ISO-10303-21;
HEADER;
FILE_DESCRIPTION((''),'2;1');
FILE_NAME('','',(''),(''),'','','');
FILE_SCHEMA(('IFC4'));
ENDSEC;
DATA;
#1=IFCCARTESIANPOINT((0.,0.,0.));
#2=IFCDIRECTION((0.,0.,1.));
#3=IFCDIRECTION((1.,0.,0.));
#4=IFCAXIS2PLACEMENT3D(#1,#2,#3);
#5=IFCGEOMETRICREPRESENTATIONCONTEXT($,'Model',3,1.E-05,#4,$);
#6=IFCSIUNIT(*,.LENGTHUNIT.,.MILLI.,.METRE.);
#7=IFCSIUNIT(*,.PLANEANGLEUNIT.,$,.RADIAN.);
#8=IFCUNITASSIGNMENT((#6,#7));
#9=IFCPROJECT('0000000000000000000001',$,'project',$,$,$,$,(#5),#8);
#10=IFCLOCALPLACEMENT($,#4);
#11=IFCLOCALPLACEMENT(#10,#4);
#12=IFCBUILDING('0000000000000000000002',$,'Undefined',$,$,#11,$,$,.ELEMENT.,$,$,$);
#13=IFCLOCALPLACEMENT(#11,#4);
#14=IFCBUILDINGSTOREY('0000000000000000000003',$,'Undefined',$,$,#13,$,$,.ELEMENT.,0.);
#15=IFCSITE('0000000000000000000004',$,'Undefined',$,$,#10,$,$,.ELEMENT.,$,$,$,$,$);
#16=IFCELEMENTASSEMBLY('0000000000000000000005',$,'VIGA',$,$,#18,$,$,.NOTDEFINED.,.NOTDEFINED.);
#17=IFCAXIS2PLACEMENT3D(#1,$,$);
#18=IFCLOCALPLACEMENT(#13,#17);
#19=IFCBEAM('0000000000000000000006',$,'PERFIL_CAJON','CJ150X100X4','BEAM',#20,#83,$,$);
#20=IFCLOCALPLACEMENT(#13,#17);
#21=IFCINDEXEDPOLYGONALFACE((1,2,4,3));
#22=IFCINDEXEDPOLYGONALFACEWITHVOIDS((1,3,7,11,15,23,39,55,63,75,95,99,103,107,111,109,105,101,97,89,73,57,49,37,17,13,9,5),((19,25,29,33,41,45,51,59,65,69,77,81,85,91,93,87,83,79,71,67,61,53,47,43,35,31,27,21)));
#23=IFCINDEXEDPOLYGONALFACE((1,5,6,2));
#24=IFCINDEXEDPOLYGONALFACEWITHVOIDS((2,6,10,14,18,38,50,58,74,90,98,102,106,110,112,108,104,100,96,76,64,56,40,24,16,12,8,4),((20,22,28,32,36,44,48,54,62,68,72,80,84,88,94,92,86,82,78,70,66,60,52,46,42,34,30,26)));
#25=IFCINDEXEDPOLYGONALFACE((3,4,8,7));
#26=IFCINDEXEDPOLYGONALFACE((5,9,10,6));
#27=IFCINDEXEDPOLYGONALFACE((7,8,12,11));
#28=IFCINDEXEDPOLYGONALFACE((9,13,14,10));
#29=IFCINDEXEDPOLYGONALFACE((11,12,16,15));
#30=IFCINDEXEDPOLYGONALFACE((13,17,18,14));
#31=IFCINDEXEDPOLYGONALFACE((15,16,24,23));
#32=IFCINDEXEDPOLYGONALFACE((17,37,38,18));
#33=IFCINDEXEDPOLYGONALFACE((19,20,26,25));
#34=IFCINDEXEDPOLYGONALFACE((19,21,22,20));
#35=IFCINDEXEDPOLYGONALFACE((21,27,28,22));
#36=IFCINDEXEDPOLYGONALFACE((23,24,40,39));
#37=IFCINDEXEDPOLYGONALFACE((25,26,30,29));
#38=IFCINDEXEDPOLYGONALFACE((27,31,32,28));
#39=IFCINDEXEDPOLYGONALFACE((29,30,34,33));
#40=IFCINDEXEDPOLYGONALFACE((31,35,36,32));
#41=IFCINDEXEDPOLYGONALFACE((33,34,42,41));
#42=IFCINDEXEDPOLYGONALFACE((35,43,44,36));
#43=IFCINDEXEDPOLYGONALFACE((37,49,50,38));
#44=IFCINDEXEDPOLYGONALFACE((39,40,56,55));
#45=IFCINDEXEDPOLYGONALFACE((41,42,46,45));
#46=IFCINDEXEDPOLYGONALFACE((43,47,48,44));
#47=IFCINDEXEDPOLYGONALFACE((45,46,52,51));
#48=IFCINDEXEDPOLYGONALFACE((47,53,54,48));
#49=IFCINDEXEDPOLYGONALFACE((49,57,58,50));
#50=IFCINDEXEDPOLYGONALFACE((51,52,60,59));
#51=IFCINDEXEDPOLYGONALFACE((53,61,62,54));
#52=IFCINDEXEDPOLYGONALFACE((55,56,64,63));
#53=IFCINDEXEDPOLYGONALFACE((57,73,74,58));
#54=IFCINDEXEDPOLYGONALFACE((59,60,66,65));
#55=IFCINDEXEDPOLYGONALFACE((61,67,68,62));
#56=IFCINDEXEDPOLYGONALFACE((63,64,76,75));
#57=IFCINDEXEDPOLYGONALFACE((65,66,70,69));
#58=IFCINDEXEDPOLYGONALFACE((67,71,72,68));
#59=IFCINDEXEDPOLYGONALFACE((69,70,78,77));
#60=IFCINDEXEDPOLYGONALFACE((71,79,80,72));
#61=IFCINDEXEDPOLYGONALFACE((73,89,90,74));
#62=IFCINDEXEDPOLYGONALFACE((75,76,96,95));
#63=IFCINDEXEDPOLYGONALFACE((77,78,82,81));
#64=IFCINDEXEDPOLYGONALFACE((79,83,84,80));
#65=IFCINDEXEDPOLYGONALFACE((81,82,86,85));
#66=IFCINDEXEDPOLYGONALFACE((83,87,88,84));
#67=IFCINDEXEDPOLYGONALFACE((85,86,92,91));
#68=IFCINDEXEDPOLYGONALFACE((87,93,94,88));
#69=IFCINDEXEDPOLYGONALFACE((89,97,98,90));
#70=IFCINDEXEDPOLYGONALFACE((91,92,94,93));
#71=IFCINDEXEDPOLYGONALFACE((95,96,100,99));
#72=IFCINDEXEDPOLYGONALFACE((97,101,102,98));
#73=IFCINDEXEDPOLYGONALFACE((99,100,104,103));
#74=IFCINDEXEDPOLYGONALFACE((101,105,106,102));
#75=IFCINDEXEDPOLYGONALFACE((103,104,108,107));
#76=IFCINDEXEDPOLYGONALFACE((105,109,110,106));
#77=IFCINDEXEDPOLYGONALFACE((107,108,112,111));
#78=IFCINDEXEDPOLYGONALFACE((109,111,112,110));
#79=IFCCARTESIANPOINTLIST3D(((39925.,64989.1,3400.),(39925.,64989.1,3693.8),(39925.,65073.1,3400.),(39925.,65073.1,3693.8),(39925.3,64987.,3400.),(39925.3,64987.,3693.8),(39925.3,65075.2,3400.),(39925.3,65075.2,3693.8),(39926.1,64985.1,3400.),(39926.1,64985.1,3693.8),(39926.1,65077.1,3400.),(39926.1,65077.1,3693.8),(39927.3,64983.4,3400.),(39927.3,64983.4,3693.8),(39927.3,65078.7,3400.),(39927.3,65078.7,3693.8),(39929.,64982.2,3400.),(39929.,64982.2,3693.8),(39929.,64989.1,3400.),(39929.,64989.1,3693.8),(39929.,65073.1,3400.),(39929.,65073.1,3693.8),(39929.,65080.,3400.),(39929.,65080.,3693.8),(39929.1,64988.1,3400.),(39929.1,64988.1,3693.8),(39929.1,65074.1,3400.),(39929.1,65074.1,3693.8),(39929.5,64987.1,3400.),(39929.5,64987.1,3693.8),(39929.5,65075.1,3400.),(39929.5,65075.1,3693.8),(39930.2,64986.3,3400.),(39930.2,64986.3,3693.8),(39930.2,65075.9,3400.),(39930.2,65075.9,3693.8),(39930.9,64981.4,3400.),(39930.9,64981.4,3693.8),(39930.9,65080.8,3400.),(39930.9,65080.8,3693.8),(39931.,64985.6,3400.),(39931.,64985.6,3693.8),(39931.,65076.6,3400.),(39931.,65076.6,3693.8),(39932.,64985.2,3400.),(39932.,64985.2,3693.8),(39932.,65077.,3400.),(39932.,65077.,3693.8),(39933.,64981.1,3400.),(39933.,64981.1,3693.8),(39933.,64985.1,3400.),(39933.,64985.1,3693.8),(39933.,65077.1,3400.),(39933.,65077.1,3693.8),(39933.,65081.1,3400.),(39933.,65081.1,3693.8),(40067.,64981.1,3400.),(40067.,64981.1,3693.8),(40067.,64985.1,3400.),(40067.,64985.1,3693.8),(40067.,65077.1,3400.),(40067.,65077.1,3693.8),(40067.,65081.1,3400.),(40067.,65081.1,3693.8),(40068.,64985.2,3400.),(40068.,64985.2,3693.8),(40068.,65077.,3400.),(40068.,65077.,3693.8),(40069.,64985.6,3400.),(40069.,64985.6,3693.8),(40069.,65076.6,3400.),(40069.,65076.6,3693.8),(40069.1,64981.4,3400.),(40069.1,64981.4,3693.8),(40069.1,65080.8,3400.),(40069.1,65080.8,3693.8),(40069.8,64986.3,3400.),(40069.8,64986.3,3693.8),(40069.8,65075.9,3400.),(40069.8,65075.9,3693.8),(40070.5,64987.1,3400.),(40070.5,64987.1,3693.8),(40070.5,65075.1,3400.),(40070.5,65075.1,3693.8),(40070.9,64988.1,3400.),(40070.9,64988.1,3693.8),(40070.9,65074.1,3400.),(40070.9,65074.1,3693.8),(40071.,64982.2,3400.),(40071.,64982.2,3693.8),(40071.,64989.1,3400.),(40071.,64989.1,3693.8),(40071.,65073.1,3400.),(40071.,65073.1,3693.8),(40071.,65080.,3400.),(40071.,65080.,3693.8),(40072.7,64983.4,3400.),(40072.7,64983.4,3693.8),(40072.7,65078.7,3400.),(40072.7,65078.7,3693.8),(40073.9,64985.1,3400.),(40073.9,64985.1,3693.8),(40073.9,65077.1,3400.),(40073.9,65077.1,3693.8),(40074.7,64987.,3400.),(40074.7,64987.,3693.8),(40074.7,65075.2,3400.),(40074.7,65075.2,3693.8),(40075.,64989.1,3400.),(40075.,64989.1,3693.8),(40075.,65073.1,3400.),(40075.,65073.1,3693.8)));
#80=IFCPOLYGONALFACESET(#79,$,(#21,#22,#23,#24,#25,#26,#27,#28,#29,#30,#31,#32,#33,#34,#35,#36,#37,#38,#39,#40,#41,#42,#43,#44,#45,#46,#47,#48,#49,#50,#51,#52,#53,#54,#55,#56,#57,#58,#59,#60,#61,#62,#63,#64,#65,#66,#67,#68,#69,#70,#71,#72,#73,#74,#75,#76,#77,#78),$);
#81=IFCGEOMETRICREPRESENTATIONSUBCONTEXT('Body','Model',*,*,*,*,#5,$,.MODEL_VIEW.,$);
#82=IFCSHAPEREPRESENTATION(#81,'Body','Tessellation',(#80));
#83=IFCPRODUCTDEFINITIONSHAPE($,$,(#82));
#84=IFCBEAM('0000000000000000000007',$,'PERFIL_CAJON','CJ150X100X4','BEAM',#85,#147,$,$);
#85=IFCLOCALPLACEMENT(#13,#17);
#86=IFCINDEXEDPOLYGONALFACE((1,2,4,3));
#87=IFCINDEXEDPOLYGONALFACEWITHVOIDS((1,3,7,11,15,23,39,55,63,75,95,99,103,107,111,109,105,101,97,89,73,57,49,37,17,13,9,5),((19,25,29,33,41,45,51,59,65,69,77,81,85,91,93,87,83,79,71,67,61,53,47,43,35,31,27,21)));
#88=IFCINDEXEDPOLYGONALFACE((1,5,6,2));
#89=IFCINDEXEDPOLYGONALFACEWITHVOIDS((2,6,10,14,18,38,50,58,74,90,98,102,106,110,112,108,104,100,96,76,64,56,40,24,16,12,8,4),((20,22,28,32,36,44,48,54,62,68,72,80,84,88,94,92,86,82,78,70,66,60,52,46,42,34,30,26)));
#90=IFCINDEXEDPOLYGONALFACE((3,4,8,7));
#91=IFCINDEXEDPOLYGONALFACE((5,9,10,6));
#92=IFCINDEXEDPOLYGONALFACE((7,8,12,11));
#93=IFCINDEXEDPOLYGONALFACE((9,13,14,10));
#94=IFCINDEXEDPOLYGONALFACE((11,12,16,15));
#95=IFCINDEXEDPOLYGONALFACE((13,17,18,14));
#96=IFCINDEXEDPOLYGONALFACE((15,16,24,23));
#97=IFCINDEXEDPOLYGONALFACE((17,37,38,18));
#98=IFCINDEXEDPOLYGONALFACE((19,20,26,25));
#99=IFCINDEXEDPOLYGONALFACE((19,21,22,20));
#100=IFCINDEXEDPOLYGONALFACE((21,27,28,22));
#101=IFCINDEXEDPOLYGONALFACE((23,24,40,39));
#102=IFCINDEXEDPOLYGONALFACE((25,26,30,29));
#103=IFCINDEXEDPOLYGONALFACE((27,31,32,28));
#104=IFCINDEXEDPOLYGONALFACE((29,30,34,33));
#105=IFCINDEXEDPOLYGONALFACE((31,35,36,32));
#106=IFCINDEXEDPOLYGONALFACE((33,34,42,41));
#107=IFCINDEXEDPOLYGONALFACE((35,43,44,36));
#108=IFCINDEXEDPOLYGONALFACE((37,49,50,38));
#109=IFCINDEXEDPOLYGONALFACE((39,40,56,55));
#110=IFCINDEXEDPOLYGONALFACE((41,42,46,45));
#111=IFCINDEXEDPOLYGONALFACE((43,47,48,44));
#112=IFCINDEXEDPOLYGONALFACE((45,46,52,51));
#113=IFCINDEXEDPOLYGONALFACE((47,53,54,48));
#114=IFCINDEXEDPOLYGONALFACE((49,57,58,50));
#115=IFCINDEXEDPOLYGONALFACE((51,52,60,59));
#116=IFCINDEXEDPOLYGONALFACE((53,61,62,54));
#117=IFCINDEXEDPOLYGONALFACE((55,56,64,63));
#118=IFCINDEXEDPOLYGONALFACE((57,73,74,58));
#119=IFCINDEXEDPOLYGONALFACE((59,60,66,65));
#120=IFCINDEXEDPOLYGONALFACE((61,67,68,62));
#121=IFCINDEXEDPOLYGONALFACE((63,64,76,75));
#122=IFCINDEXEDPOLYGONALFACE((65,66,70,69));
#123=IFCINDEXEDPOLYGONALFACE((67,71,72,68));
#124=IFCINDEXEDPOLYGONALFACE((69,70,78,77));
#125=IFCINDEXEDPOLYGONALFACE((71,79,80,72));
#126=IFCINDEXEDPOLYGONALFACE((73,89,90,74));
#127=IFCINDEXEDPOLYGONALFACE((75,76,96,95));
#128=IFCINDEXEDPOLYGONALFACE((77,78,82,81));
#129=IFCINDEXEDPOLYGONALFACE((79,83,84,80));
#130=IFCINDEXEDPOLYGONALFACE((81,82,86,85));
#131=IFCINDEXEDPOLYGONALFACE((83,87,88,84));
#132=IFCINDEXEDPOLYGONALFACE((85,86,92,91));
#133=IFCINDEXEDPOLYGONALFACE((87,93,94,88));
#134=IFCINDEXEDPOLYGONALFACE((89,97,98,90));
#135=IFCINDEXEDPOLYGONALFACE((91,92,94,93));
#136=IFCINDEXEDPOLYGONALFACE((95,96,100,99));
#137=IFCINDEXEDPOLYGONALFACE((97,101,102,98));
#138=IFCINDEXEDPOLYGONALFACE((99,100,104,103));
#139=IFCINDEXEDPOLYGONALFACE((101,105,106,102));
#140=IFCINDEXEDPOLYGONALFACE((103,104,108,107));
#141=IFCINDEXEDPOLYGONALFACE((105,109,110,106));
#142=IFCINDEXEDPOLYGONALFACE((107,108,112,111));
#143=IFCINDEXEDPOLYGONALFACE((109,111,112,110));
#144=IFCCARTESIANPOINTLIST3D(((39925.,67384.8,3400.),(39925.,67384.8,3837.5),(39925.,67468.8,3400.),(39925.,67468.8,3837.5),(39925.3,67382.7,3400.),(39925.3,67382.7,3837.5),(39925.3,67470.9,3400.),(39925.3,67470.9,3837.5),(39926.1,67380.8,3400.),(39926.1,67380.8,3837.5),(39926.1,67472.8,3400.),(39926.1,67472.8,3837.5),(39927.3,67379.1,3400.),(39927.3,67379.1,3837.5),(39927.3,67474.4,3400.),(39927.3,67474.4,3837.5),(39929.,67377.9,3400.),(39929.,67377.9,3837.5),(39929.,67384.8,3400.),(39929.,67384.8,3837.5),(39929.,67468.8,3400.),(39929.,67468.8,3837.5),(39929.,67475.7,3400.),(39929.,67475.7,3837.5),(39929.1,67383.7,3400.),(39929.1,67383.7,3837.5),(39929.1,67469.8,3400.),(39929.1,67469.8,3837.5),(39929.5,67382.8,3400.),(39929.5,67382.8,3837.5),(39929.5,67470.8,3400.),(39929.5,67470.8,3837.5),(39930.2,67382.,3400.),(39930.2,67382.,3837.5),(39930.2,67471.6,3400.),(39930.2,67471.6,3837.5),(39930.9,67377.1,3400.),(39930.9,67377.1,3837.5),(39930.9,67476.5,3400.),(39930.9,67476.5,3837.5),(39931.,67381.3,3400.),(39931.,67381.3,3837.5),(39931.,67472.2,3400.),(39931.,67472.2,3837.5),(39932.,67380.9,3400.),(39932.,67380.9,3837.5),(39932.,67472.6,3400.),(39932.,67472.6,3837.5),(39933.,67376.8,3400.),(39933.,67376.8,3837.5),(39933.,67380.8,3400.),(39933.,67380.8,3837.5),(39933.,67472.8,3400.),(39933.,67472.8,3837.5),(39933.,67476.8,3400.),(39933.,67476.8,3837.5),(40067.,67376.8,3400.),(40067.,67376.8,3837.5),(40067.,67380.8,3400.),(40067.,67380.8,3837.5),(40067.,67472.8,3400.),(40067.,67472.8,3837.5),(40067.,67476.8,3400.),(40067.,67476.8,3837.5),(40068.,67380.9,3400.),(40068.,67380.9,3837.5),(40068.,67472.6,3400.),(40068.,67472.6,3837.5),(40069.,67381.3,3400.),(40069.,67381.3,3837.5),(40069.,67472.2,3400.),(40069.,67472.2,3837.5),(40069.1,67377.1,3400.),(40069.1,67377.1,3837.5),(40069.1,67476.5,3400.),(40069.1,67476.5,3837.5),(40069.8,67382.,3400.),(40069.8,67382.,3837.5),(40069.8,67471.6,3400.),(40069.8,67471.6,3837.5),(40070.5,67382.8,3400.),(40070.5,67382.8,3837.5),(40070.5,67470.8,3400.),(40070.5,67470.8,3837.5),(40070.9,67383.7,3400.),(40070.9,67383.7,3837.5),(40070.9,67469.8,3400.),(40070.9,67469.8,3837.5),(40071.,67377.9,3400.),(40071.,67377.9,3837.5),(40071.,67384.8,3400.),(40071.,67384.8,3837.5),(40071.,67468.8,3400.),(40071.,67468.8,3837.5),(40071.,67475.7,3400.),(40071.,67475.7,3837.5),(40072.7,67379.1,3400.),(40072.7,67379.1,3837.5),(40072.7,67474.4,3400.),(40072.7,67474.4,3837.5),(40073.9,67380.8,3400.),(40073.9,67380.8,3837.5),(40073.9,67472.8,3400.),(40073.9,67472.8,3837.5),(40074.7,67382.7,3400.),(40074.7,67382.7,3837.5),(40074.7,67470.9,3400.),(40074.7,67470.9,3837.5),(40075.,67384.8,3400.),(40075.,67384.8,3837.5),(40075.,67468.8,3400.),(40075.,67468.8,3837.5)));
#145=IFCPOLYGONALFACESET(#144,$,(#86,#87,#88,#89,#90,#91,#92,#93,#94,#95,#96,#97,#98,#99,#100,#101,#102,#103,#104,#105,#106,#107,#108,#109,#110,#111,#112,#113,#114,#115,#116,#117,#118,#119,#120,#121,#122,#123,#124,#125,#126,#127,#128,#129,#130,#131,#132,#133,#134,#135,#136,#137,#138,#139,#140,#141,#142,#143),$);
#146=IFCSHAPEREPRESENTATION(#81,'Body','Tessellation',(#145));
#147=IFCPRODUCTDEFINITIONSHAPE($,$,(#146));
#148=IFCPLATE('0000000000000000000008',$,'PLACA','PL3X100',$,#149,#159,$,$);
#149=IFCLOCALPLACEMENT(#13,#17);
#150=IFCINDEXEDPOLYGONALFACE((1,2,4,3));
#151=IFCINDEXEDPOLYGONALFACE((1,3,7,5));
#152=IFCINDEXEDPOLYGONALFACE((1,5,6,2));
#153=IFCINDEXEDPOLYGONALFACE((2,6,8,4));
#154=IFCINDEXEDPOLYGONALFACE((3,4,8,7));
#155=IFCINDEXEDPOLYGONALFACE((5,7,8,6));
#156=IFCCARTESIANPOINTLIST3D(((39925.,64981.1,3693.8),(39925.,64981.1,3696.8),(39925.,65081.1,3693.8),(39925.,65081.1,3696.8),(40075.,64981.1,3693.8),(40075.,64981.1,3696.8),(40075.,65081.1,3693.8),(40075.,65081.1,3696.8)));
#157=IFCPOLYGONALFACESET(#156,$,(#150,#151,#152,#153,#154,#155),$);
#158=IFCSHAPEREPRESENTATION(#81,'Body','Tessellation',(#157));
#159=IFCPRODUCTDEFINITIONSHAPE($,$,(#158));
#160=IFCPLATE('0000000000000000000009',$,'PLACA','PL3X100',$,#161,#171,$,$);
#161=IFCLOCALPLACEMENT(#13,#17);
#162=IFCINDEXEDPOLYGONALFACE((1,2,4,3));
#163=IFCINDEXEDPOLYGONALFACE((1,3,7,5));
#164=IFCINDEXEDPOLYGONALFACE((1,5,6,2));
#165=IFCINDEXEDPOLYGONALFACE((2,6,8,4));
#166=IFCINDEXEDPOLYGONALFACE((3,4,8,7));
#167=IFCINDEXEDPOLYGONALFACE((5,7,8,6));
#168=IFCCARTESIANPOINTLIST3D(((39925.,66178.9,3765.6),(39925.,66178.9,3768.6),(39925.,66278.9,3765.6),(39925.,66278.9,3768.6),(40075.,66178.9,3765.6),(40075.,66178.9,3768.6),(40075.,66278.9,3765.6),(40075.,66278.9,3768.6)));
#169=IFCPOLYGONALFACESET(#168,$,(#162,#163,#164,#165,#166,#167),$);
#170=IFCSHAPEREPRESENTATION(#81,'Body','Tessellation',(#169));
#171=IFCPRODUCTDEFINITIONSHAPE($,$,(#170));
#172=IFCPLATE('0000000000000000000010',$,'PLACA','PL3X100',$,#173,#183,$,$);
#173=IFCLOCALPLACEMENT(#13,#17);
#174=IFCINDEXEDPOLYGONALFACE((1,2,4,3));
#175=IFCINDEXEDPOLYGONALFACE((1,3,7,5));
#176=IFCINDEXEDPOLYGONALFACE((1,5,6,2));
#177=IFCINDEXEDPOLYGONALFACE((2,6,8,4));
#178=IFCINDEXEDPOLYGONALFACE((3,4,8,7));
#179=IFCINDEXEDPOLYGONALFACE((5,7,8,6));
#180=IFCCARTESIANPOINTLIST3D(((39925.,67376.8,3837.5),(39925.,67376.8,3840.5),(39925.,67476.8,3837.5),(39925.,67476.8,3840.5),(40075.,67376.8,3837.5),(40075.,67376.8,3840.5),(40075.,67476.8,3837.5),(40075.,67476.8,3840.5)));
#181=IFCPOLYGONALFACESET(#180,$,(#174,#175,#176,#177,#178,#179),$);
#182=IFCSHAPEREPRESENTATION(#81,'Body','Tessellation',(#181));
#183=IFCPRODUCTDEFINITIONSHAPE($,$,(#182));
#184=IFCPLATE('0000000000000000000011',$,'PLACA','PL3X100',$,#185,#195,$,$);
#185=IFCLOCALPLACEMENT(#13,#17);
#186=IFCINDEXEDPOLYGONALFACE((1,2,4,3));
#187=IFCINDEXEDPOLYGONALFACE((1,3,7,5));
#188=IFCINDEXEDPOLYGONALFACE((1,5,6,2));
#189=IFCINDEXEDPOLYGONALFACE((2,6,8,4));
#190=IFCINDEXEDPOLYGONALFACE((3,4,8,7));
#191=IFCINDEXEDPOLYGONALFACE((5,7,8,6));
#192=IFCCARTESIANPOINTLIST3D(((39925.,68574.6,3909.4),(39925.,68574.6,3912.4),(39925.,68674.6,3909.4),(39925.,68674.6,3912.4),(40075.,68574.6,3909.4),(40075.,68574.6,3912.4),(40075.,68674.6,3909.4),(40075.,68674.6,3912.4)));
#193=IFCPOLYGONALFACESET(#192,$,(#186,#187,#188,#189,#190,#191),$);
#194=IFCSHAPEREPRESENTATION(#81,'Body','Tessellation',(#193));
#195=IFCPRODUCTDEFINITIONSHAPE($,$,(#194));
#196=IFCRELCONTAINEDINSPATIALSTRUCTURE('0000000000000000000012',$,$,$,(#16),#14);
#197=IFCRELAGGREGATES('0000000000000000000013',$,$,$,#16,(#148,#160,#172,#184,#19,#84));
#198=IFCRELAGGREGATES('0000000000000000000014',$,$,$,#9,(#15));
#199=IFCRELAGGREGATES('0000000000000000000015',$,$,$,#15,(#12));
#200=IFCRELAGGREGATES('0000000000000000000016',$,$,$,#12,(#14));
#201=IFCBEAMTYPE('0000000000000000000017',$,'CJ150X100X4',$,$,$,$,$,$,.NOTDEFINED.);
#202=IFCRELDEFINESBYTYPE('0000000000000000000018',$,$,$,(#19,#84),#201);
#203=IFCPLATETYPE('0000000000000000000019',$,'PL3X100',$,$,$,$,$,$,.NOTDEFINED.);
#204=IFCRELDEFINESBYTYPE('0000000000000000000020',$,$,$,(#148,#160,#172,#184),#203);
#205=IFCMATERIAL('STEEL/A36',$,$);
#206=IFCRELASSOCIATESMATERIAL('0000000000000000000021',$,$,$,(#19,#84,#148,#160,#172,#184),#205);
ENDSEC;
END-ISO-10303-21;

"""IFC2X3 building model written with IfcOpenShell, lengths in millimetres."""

from ifc_helpers import new_model, si_unit, frame, origin_with_axes, origin_2d_with_axis, place, context, subcontext, project, spatial, polyline, hollow_rectangle, outline, extrude, material, type_object, element, aggregate, save


model = new_model("IFC2X3")

# Units and contexts
model_context = context("Model", 3, precision=1e-05, world=origin_with_axes())
body_context = subcontext(model_context, "Body", "Model", "MODEL_VIEW")
ifc_project = project(units=[si_unit("LENGTHUNIT", "METRE", prefix="MILLI"), si_unit("PLANEANGLEUNIT", "RADIAN")], contexts=[model_context])

# Site, building, storey
site_placement = place(None, origin_with_axes())
site = spatial("IfcSite", under=ifc_project, at=site_placement, Name="Undefined", CompositionType="ELEMENT")
building_placement = place(site_placement, origin_with_axes())
building = spatial("IfcBuilding", under=site, at=building_placement, Name="Undefined", CompositionType="ELEMENT")
storey_placement = place(building_placement, origin_with_axes())
storey = spatial("IfcBuildingStorey", under=building, at=storey_placement, Name="Undefined", CompositionType="ELEMENT", Elevation=0.0)

# Shared definitions
ifc_material_1 = material(Name="STEEL/A36")
beam_type = type_object("IfcBeamType", Name="CJ150X100X4", PredefinedType="NOTDEFINED")

# Element assembly, beams, plates
assembly_1_placement = place(storey_placement, origin_with_axes())
assembly_1 = element("IfcElementAssembly", 1, at=assembly_1_placement, inside=storey, Name="VIGA", AssemblyPlace="NOTDEFINED", PredefinedType="NOTDEFINED")
beam_1_placement = place(assembly_1_placement, frame((40000.0, 65031.1, 3693.8), z_axis=(-1.0, 0.0, 0.0), x_axis=(0.0, 0.0, -1.0)))
beam_1 = element("IfcBeam", 2, at=beam_1_placement, type_object=beam_type, material=ifc_material_1, Name="PERFIL_CAJON", Description="CJ150X100X4", ObjectType="BEAM", context=body_context, shape_type="SweptSolid", body=[
    extrude(hollow_rectangle(XDim=100.0, YDim=150.0, WallThickness=4.0, InnerFilletRadius=4.0, OuterFilletRadius=8.0, at=origin_2d_with_axis()), frame((293.8, 0.0, 0.0), z_axis=(-1.0, 0.0, 0.0), x_axis=(0.0, -1.0, 0.0)), (0.0, 0.0, 1.0), 293.8),
])
beam_2_placement = place(assembly_1_placement, frame((40000.0, 67426.8, 3837.5), z_axis=(-1.0, 0.0, 0.0), x_axis=(0.0, 0.0, -1.0)))
beam_2 = element("IfcBeam", 3, at=beam_2_placement, type_object=beam_type, material=ifc_material_1, Name="PERFIL_CAJON", Description="CJ150X100X4", ObjectType="BEAM", context=body_context, shape_type="SweptSolid", body=[
    extrude(hollow_rectangle(XDim=100.0, YDim=150.0, WallThickness=4.0, InnerFilletRadius=4.0, OuterFilletRadius=8.0, at=origin_2d_with_axis()), frame((437.5, 0.0, 0.0), z_axis=(-1.0, 0.0, 0.0), x_axis=(0.0, -1.0, 0.0)), (0.0, 0.0, 1.0), 437.5),
])
plate_type_1 = type_object("IfcPlateType", Name="PL3X100", PredefinedType="NOTDEFINED")
plate_1_placement = place(assembly_1_placement, frame((40075.0, 65081.1, 3695.3), z_axis=(0.0, 0.0, -1.0), x_axis=(0.0, -1.0, 0.0)))
plate_1 = element("IfcPlate", 4, at=plate_1_placement, type_object=plate_type_1, material=ifc_material_1, Name="PLACA", Description="PL3X100", context=body_context, shape_type="SweptSolid", body=[
    extrude(outline(polyline([(0.0, 0.0), (100.0, 0.0), (100.0, 150.0), (0.0, 150.0), (0.0, 0.0)])), frame((0.0, 0.0, -1.5), z_axis=(0.0, 0.0, 1.0), x_axis=(1.0, 0.0, 0.0)), (0.0, 0.0, 1.0), 3.0),
])
plate_2_placement = place(assembly_1_placement, frame((40075.0, 66278.9, 3767.1), z_axis=(0.0, 0.0, -1.0), x_axis=(0.0, -1.0, 0.0)))
plate_2 = element("IfcPlate", 5, at=plate_2_placement, type_object=plate_type_1, material=ifc_material_1, Name="PLACA", Description="PL3X100", context=body_context, shape_type="SweptSolid", body=[
    extrude(outline(polyline([(0.0, 0.0), (100.0, 0.0), (100.0, 150.0), (0.0, 150.0), (0.0, 0.0)])), frame((0.0, 0.0, -1.5), z_axis=(0.0, 0.0, 1.0), x_axis=(1.0, 0.0, 0.0)), (0.0, 0.0, 1.0), 3.0),
])
plate_3_placement = place(assembly_1_placement, frame((40075.0, 67476.8, 3839.0), z_axis=(0.0, 0.0, -1.0), x_axis=(0.0, -1.0, 0.0)))
plate_3 = element("IfcPlate", 6, at=plate_3_placement, type_object=plate_type_1, material=ifc_material_1, Name="PLACA", Description="PL3X100", context=body_context, shape_type="SweptSolid", body=[
    extrude(outline(polyline([(0.0, 0.0), (100.0, 0.0), (100.0, 150.0), (0.0, 150.0), (0.0, 0.0)])), frame((0.0, 0.0, -1.5), z_axis=(0.0, 0.0, 1.0), x_axis=(1.0, 0.0, 0.0)), (0.0, 0.0, 1.0), 3.0),
])
plate_4_placement = place(assembly_1_placement, frame((40075.0, 68674.6, 3910.9), z_axis=(0.0, 0.0, -1.0), x_axis=(0.0, -1.0, 0.0)))
plate_4 = element("IfcPlate", 7, at=plate_4_placement, type_object=plate_type_1, material=ifc_material_1, Name="PLACA", Description="PL3X100", context=body_context, shape_type="SweptSolid", body=[
    extrude(outline(polyline([(0.0, 0.0), (100.0, 0.0), (100.0, 150.0), (0.0, 150.0), (0.0, 0.0)])), frame((0.0, 0.0, -1.5), z_axis=(0.0, 0.0, 1.0), x_axis=(1.0, 0.0, 0.0)), (0.0, 0.0, 1.0), 3.0),
])
aggregate(assembly_1, [plate_1, plate_2, plate_3, plate_4, beam_1, beam_2])

save(model, "model.ifc")
